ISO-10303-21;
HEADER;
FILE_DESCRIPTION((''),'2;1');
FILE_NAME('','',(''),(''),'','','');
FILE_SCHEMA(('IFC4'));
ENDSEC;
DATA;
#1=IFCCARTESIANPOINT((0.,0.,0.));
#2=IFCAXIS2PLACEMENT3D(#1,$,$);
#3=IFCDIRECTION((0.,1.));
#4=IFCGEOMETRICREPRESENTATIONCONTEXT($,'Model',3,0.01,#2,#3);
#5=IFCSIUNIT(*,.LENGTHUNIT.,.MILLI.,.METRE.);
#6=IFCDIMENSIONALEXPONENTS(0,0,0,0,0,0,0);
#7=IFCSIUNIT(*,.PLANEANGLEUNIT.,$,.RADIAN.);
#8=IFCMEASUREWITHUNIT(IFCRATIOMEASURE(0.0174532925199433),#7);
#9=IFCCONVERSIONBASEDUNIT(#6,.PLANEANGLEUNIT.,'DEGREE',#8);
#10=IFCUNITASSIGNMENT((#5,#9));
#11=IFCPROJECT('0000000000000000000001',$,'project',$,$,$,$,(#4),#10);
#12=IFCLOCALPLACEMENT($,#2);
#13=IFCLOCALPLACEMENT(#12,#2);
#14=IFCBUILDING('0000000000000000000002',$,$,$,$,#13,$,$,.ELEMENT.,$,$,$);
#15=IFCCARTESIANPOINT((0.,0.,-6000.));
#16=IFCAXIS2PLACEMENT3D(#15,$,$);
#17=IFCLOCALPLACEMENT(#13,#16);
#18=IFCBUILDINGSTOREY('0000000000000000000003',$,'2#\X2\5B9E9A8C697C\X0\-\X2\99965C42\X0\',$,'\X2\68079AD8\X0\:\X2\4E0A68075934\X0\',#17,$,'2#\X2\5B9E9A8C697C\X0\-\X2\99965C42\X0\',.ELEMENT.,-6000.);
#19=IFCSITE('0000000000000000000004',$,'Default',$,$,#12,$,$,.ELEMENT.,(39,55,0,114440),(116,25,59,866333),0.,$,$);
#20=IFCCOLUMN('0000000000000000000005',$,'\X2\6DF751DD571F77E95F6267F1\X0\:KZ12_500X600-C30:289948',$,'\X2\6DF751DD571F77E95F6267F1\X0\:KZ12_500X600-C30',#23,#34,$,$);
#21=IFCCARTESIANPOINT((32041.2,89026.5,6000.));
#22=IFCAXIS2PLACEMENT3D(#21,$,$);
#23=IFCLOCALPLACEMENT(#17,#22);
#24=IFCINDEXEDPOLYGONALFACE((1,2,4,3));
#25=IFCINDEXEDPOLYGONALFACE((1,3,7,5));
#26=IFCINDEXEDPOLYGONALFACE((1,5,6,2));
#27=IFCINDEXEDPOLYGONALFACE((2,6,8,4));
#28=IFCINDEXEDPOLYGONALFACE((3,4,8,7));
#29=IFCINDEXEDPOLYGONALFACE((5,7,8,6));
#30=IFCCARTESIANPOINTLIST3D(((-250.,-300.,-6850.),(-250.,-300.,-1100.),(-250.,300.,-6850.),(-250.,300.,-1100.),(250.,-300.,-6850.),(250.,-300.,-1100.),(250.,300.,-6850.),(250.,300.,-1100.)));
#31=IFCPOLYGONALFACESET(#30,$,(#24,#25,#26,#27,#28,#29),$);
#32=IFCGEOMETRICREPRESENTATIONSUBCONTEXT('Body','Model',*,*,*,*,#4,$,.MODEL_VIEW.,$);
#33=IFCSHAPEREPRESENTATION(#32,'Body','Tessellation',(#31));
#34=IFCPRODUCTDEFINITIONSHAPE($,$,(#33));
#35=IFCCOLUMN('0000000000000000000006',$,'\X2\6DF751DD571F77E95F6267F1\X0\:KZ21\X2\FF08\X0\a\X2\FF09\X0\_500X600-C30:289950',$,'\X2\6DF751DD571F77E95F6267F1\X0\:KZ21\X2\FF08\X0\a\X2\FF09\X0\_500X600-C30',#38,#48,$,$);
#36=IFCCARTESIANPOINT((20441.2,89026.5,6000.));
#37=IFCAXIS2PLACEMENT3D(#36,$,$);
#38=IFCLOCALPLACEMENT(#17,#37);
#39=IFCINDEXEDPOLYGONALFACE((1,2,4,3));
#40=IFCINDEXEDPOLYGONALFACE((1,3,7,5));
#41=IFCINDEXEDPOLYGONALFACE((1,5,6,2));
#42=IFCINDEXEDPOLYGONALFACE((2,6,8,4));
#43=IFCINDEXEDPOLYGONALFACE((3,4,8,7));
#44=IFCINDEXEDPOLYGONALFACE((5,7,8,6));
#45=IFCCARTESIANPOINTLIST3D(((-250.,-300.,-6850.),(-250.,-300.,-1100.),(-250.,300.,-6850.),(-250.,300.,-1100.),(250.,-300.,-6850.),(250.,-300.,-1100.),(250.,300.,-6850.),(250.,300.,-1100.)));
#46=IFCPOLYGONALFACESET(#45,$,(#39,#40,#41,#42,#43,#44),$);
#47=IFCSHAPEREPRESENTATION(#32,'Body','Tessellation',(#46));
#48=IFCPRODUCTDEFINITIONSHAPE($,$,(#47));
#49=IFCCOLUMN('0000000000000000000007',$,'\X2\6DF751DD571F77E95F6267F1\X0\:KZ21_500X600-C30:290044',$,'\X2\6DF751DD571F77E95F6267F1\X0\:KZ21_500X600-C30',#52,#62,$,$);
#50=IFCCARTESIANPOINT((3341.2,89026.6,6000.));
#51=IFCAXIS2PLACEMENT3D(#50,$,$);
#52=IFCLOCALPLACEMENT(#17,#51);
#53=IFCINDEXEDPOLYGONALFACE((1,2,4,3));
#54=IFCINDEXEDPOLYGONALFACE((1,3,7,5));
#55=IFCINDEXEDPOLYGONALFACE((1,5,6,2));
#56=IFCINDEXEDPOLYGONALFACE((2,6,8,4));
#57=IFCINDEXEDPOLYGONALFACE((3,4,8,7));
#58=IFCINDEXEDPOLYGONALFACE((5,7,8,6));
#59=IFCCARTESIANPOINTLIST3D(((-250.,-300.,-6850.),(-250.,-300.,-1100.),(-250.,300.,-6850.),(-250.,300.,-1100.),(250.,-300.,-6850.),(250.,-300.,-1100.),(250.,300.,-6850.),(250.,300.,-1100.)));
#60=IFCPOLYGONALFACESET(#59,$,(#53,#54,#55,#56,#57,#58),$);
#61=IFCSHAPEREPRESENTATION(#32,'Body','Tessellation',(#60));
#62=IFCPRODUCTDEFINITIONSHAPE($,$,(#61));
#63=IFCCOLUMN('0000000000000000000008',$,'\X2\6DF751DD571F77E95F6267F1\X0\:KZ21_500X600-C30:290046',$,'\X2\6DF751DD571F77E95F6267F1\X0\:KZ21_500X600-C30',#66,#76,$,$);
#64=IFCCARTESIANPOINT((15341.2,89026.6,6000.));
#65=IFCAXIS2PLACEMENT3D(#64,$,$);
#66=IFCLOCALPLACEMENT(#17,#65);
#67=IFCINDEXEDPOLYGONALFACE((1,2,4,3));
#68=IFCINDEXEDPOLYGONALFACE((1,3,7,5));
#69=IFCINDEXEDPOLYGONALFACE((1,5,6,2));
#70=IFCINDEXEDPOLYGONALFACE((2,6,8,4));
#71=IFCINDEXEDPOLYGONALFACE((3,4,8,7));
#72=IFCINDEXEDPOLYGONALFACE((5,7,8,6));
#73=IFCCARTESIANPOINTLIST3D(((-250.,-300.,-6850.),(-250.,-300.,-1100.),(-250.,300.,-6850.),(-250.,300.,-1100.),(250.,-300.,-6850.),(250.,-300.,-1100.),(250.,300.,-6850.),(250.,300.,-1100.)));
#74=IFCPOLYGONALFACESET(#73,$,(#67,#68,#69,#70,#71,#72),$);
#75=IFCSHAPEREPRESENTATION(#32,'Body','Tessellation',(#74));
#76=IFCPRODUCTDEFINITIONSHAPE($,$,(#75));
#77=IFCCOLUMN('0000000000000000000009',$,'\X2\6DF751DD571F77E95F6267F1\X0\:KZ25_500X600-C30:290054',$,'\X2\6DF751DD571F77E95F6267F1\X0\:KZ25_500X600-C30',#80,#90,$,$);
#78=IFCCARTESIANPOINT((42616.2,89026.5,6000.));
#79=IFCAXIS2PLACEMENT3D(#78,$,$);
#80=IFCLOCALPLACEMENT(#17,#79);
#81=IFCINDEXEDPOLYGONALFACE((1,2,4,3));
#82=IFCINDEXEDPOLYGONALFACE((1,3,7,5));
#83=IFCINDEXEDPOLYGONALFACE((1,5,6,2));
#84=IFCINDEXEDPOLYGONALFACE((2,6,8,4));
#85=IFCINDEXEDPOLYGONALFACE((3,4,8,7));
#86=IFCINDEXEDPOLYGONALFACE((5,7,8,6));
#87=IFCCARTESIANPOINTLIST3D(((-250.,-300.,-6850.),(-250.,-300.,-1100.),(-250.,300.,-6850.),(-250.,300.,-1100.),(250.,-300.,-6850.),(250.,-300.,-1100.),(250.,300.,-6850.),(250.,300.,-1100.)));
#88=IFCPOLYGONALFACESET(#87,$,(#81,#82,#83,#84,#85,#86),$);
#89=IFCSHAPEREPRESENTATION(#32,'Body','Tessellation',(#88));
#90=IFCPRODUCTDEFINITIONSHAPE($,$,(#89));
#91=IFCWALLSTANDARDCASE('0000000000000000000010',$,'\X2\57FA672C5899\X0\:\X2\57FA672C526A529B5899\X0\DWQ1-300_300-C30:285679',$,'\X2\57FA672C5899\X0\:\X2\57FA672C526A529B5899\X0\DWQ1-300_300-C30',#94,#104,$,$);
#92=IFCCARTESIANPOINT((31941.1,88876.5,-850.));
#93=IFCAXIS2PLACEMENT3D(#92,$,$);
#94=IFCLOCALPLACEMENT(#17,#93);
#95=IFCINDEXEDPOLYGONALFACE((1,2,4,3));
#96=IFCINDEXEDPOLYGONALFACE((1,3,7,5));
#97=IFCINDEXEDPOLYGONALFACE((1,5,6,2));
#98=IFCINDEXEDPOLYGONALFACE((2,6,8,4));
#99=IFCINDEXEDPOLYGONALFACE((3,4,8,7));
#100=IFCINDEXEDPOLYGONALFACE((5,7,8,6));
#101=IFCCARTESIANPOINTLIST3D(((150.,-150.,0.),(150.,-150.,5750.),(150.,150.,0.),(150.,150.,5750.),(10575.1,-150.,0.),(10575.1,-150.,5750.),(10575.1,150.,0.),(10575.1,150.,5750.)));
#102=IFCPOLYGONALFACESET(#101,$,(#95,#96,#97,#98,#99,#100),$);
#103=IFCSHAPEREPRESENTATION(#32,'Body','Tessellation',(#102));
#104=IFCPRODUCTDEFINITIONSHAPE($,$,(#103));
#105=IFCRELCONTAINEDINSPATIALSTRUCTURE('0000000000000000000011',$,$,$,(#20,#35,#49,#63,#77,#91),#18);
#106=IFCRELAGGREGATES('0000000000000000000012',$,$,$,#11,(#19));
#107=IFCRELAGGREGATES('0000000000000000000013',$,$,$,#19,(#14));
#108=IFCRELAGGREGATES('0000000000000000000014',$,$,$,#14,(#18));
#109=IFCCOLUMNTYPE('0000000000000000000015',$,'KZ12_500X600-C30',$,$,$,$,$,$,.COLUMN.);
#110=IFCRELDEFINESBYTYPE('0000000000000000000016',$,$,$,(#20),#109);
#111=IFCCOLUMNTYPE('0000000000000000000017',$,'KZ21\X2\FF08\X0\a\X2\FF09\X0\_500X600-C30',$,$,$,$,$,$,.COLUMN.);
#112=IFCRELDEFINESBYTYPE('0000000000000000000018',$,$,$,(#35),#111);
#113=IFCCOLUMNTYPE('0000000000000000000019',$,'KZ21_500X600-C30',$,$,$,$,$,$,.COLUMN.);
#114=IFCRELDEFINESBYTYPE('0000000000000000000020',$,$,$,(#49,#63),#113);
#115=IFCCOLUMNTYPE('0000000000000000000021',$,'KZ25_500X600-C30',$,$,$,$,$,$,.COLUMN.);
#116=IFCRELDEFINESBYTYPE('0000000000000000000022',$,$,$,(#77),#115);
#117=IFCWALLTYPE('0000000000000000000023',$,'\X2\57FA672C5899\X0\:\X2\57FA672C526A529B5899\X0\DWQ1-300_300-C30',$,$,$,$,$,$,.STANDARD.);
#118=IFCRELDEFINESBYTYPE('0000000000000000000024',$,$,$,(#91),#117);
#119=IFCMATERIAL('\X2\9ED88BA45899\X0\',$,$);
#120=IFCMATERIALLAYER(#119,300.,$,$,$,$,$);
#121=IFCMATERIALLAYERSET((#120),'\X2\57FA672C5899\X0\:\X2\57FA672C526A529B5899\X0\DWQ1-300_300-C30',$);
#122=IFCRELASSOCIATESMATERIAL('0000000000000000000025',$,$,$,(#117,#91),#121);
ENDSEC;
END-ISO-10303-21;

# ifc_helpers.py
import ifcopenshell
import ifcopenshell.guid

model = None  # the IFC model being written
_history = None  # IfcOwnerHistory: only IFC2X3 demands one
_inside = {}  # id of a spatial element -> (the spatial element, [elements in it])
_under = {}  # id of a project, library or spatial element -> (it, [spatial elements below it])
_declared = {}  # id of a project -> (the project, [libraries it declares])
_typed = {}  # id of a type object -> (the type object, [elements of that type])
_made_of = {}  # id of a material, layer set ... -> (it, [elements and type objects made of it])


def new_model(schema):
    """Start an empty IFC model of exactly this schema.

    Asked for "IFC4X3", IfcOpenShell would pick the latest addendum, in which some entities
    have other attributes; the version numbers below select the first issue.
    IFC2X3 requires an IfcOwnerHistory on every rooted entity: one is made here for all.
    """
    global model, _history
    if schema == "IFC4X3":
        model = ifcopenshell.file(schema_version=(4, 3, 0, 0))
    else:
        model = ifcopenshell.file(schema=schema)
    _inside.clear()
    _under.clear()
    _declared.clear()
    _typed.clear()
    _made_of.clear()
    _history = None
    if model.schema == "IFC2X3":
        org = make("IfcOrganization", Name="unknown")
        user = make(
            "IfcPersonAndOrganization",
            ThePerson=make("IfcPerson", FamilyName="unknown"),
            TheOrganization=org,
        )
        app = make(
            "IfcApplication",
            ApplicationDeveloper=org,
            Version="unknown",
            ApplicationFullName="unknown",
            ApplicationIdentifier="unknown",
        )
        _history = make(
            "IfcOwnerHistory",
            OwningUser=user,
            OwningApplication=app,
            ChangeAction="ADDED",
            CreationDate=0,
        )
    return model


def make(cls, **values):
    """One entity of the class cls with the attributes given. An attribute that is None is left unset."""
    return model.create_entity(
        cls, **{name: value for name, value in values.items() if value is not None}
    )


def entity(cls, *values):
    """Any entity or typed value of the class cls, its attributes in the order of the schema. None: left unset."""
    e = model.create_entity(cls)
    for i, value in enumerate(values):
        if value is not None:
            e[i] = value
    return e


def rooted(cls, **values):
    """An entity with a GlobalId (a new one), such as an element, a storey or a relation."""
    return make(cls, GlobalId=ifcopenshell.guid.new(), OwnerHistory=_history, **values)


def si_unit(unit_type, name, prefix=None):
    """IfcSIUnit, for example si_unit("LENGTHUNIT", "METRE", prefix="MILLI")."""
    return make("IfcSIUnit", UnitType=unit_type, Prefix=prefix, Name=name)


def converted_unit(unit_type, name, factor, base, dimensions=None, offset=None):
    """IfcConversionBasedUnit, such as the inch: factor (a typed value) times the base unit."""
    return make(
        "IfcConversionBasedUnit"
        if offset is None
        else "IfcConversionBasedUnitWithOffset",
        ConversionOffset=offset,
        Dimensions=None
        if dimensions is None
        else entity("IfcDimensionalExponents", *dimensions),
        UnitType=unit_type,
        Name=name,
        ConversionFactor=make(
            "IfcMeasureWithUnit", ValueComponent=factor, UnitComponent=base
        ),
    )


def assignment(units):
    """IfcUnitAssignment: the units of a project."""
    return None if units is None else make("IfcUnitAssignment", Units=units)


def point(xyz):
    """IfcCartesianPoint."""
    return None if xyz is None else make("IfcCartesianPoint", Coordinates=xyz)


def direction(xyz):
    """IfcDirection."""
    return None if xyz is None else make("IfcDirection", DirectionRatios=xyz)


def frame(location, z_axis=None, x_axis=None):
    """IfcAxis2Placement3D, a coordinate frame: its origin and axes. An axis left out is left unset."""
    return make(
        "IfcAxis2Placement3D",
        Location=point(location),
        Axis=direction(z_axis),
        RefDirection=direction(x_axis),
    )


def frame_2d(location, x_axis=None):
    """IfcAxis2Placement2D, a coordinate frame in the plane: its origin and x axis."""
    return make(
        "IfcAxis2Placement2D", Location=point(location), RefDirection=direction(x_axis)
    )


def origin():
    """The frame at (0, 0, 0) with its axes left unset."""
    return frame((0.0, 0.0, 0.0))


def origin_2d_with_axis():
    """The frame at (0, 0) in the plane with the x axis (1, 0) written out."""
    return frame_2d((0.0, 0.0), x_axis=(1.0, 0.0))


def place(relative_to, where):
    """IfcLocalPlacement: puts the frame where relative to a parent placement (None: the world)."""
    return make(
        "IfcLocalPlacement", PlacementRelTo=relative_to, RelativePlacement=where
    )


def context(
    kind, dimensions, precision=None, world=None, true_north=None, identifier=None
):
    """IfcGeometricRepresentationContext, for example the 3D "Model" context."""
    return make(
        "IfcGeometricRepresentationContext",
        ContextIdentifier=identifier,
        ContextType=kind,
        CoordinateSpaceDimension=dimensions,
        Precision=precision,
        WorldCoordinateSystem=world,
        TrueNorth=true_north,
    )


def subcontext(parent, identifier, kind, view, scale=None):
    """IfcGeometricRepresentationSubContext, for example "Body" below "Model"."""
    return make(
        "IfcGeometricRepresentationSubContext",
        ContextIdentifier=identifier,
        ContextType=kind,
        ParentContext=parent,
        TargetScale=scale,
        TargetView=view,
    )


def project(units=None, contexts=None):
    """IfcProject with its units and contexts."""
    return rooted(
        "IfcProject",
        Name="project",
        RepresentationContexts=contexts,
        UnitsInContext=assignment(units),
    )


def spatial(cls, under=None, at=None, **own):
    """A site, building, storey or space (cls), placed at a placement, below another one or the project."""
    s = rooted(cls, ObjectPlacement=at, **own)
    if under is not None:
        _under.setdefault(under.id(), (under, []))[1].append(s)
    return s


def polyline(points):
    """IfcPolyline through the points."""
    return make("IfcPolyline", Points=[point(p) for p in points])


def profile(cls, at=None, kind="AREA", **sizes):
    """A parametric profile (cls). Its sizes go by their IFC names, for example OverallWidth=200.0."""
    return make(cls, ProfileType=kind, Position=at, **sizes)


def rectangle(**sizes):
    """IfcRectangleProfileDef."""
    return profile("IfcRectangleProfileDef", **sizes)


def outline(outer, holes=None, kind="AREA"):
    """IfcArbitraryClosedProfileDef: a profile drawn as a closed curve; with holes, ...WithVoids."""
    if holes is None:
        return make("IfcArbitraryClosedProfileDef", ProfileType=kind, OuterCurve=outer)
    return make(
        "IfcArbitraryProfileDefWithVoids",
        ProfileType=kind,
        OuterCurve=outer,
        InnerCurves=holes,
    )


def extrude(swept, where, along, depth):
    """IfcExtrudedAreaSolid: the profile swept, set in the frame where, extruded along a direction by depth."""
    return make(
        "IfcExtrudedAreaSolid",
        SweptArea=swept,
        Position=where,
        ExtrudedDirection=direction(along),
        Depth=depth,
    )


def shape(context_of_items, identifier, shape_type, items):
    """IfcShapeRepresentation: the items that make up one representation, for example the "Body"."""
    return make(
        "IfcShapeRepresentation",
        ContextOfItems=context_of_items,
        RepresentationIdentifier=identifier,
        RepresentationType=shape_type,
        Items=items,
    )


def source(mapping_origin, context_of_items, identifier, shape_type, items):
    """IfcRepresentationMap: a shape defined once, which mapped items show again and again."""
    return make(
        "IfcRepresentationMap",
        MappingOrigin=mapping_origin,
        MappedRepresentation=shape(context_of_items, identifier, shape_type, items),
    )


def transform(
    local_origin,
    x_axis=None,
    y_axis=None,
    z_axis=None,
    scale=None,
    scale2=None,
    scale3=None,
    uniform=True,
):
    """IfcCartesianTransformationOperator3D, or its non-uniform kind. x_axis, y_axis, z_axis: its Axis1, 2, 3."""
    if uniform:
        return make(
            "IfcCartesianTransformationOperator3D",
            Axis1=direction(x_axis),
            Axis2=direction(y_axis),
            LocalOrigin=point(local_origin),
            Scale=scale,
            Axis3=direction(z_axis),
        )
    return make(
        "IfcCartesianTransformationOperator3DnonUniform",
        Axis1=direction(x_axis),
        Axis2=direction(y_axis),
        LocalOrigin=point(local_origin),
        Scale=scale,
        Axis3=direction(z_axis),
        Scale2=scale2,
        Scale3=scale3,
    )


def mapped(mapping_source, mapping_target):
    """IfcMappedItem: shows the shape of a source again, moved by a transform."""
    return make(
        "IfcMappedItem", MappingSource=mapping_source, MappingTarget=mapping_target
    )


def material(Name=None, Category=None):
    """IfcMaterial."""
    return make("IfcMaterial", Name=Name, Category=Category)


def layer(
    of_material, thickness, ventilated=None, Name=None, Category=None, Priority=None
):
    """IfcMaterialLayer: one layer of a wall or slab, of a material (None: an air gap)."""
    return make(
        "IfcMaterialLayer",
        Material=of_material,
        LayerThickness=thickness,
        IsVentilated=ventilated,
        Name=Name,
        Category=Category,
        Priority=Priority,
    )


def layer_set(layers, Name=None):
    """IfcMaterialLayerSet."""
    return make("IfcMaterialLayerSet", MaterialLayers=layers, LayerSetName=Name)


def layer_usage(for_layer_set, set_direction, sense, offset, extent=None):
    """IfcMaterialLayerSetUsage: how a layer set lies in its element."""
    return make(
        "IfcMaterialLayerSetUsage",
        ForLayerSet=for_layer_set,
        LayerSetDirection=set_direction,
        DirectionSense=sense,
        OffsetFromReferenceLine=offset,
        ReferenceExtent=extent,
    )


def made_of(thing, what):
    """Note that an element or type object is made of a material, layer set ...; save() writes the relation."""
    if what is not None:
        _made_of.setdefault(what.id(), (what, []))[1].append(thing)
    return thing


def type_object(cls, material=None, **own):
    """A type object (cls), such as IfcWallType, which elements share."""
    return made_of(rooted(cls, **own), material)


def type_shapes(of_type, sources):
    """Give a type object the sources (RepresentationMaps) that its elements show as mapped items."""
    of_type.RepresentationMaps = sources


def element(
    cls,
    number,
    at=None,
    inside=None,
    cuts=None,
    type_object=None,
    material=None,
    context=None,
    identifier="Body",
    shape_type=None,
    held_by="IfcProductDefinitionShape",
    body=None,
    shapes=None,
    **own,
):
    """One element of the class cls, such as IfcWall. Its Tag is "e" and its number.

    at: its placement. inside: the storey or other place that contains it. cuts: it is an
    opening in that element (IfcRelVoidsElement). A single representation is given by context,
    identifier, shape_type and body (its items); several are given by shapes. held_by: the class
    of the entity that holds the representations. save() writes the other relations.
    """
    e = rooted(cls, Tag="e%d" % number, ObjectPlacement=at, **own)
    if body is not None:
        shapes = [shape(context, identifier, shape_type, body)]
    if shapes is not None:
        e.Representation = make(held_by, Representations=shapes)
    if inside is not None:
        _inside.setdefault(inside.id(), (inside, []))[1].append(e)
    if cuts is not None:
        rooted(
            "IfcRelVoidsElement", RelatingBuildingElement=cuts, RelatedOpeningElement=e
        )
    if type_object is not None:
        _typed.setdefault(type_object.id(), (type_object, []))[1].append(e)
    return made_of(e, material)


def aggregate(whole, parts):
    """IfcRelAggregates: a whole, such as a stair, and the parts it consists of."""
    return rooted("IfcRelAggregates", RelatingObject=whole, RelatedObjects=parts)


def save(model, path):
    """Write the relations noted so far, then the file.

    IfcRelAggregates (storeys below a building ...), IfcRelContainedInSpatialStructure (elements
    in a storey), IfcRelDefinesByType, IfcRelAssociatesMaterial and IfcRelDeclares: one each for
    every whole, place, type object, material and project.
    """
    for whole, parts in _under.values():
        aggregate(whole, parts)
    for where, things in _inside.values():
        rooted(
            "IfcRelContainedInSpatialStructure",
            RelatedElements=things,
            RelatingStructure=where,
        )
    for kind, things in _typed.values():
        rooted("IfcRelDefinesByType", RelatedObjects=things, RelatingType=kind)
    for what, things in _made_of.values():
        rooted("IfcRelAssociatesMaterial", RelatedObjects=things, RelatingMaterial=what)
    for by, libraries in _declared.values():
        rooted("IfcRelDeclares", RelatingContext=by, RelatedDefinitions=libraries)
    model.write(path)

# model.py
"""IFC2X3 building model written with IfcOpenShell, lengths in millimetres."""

from ifc_helpers import new_model, entity, si_unit, converted_unit, direction, frame, origin, origin_2d_with_axis, place, context, subcontext, project, spatial, polyline, rectangle, outline, extrude, source, transform, mapped, material, layer, layer_set, layer_usage, type_object, type_shapes, element, save


model = new_model("IFC2X3")

# Units and contexts
model_context = context("Model", 3, precision=0.01, world=origin(), true_north=direction((0.0, 1.0)))
body_context = subcontext(model_context, "Body", "Model", "MODEL_VIEW")
ifc_project = project(units=[si_unit("LENGTHUNIT", "METRE", prefix="MILLI"), converted_unit("PLANEANGLEUNIT", "DEGREE", entity("IfcRatioMeasure", 0.0174532925199433), si_unit("PLANEANGLEUNIT", "RADIAN"), dimensions=[0, 0, 0, 0, 0, 0, 0])], contexts=[model_context])

# Site, building, storey
site_placement = place(None, origin())
site = spatial("IfcSite", under=ifc_project, at=site_placement, Name="Default", CompositionType="ELEMENT", RefLatitude=(39, 55, 0, 114440), RefLongitude=(116, 25, 59, 866333), RefElevation=0.0)
building_placement = place(site_placement, origin())
building = spatial("IfcBuilding", under=site, at=building_placement, CompositionType="ELEMENT")
storey_placement = place(building_placement, frame((0.0, 0.0, -6000.0)))
storey = spatial("IfcBuildingStorey", under=building, at=storey_placement, Name="2#实验楼-首层", ObjectType="标高:上标头", LongName="2#实验楼-首层", CompositionType="ELEMENT", Elevation=-6000.0)

# Columns
column_type_1 = type_object("IfcColumnType", Name="KZ12_500X600-C30", PredefinedType="COLUMN")
shared_shape_1 = source(origin(), body_context, "Body", "SweptSolid", [
    extrude(rectangle(XDim=600.0, YDim=500.0, at=origin_2d_with_axis()), frame((0.0, 0.0, -6850.0), z_axis=(0.0, 0.0, 1.0), x_axis=(0.0, -1.0, 0.0)), (0.0, 0.0, 1.0), 5750.0),
])
type_shapes(column_type_1, [shared_shape_1])
column_1_placement = place(storey_placement, frame((32041.2, 89026.5, 6000.0)))
element("IfcColumn", 1, at=column_1_placement, inside=storey, type_object=column_type_1, Name="混凝土矩形柱:KZ12_500X600-C30:289948", ObjectType="混凝土矩形柱:KZ12_500X600-C30", context=body_context, shape_type="MappedRepresentation", body=[
    mapped(shared_shape_1, transform((0.0, 0.0, 0.0), scale=1.0)),
])
column_type_2 = type_object("IfcColumnType", Name="KZ21（a）_500X600-C30", PredefinedType="COLUMN")
shared_shape_2 = source(origin(), body_context, "Body", "SweptSolid", [
    extrude(rectangle(XDim=600.0, YDim=500.0, at=origin_2d_with_axis()), frame((0.0, 0.0, -6850.0), z_axis=(0.0, 0.0, 1.0), x_axis=(0.0, -1.0, 0.0)), (0.0, 0.0, 1.0), 5750.0),
])
type_shapes(column_type_2, [shared_shape_2])
column_2_placement = place(storey_placement, frame((20441.2, 89026.5, 6000.0)))
element("IfcColumn", 2, at=column_2_placement, inside=storey, type_object=column_type_2, Name="混凝土矩形柱:KZ21（a）_500X600-C30:289950", ObjectType="混凝土矩形柱:KZ21（a）_500X600-C30", context=body_context, shape_type="MappedRepresentation", body=[
    mapped(shared_shape_2, transform((0.0, 0.0, 0.0), scale=1.0)),
])
column_type_3 = type_object("IfcColumnType", Name="KZ21_500X600-C30", PredefinedType="COLUMN")
shared_shape_3 = source(origin(), body_context, "Body", "SweptSolid", [
    extrude(rectangle(XDim=600.0, YDim=500.0, at=origin_2d_with_axis()), frame((0.0, 0.0, -6850.0), z_axis=(0.0, 0.0, 1.0), x_axis=(0.0, -1.0, 0.0)), (0.0, 0.0, 1.0), 5750.0),
])
type_shapes(column_type_3, [shared_shape_3])
for number, where, name in (
    (3, (3341.2, 89026.6, 6000.0), "混凝土矩形柱:KZ21_500X600-C30:290044"),
    (4, (15341.2, 89026.6, 6000.0), "混凝土矩形柱:KZ21_500X600-C30:290046"),
):
    element("IfcColumn", number, at=place(storey_placement, frame(where)), inside=storey, type_object=column_type_3, Name=name, ObjectType="混凝土矩形柱:KZ21_500X600-C30", context=body_context, shape_type="MappedRepresentation", body=[
        mapped(shared_shape_3, transform((0.0, 0.0, 0.0), scale=1.0)),
    ])
column_type_4 = type_object("IfcColumnType", Name="KZ25_500X600-C30", PredefinedType="COLUMN")
shared_shape_4 = source(origin(), body_context, "Body", "SweptSolid", [
    extrude(rectangle(XDim=600.0, YDim=500.0, at=origin_2d_with_axis()), frame((0.0, 0.0, -6850.0), z_axis=(0.0, 0.0, 1.0), x_axis=(0.0, -1.0, 0.0)), (0.0, 0.0, 1.0), 5750.0),
])
type_shapes(column_type_4, [shared_shape_4])
column_3_placement = place(storey_placement, frame((42616.2, 89026.5, 6000.0)))
element("IfcColumn", 5, at=column_3_placement, inside=storey, type_object=column_type_4, Name="混凝土矩形柱:KZ25_500X600-C30:290054", ObjectType="混凝土矩形柱:KZ25_500X600-C30", context=body_context, shape_type="MappedRepresentation", body=[
    mapped(shared_shape_4, transform((0.0, 0.0, 0.0), scale=1.0)),
])

# Wall
ifc_material_1 = material(Name="默认墙")
ifc_layer_1 = layer(ifc_material_1, 300.0)
ifc_layer_set_1 = layer_set([ifc_layer_1], Name="基本墙:基本剪力墙DWQ1-300_300-C30")
ifc_layer_usage_1 = layer_usage(ifc_layer_set_1, "AXIS2", "NEGATIVE", 150.0)
wall_type_1 = type_object("IfcWallType", Name="基本墙:基本剪力墙DWQ1-300_300-C30", PredefinedType="STANDARD", material=ifc_layer_set_1)
wall_1_placement = place(storey_placement, frame((31941.1, 88876.5, -850.0)))
element("IfcWallStandardCase", 6, at=wall_1_placement, inside=storey, type_object=wall_type_1, material=ifc_layer_usage_1, Name="基本墙:基本剪力墙DWQ1-300_300-C30:285679", ObjectType="基本墙:基本剪力墙DWQ1-300_300-C30", context=body_context, shape_type="SweptSolid", body=[
    extrude(outline(polyline([(10575.1, -150.0), (10575.1, 150.0), (150.0, 150.0), (150.0, -150.0), (10575.1, -150.0)])), origin(), (0.0, 0.0, 1.0), 5750.0),
])

save(model, "model.ifc")
